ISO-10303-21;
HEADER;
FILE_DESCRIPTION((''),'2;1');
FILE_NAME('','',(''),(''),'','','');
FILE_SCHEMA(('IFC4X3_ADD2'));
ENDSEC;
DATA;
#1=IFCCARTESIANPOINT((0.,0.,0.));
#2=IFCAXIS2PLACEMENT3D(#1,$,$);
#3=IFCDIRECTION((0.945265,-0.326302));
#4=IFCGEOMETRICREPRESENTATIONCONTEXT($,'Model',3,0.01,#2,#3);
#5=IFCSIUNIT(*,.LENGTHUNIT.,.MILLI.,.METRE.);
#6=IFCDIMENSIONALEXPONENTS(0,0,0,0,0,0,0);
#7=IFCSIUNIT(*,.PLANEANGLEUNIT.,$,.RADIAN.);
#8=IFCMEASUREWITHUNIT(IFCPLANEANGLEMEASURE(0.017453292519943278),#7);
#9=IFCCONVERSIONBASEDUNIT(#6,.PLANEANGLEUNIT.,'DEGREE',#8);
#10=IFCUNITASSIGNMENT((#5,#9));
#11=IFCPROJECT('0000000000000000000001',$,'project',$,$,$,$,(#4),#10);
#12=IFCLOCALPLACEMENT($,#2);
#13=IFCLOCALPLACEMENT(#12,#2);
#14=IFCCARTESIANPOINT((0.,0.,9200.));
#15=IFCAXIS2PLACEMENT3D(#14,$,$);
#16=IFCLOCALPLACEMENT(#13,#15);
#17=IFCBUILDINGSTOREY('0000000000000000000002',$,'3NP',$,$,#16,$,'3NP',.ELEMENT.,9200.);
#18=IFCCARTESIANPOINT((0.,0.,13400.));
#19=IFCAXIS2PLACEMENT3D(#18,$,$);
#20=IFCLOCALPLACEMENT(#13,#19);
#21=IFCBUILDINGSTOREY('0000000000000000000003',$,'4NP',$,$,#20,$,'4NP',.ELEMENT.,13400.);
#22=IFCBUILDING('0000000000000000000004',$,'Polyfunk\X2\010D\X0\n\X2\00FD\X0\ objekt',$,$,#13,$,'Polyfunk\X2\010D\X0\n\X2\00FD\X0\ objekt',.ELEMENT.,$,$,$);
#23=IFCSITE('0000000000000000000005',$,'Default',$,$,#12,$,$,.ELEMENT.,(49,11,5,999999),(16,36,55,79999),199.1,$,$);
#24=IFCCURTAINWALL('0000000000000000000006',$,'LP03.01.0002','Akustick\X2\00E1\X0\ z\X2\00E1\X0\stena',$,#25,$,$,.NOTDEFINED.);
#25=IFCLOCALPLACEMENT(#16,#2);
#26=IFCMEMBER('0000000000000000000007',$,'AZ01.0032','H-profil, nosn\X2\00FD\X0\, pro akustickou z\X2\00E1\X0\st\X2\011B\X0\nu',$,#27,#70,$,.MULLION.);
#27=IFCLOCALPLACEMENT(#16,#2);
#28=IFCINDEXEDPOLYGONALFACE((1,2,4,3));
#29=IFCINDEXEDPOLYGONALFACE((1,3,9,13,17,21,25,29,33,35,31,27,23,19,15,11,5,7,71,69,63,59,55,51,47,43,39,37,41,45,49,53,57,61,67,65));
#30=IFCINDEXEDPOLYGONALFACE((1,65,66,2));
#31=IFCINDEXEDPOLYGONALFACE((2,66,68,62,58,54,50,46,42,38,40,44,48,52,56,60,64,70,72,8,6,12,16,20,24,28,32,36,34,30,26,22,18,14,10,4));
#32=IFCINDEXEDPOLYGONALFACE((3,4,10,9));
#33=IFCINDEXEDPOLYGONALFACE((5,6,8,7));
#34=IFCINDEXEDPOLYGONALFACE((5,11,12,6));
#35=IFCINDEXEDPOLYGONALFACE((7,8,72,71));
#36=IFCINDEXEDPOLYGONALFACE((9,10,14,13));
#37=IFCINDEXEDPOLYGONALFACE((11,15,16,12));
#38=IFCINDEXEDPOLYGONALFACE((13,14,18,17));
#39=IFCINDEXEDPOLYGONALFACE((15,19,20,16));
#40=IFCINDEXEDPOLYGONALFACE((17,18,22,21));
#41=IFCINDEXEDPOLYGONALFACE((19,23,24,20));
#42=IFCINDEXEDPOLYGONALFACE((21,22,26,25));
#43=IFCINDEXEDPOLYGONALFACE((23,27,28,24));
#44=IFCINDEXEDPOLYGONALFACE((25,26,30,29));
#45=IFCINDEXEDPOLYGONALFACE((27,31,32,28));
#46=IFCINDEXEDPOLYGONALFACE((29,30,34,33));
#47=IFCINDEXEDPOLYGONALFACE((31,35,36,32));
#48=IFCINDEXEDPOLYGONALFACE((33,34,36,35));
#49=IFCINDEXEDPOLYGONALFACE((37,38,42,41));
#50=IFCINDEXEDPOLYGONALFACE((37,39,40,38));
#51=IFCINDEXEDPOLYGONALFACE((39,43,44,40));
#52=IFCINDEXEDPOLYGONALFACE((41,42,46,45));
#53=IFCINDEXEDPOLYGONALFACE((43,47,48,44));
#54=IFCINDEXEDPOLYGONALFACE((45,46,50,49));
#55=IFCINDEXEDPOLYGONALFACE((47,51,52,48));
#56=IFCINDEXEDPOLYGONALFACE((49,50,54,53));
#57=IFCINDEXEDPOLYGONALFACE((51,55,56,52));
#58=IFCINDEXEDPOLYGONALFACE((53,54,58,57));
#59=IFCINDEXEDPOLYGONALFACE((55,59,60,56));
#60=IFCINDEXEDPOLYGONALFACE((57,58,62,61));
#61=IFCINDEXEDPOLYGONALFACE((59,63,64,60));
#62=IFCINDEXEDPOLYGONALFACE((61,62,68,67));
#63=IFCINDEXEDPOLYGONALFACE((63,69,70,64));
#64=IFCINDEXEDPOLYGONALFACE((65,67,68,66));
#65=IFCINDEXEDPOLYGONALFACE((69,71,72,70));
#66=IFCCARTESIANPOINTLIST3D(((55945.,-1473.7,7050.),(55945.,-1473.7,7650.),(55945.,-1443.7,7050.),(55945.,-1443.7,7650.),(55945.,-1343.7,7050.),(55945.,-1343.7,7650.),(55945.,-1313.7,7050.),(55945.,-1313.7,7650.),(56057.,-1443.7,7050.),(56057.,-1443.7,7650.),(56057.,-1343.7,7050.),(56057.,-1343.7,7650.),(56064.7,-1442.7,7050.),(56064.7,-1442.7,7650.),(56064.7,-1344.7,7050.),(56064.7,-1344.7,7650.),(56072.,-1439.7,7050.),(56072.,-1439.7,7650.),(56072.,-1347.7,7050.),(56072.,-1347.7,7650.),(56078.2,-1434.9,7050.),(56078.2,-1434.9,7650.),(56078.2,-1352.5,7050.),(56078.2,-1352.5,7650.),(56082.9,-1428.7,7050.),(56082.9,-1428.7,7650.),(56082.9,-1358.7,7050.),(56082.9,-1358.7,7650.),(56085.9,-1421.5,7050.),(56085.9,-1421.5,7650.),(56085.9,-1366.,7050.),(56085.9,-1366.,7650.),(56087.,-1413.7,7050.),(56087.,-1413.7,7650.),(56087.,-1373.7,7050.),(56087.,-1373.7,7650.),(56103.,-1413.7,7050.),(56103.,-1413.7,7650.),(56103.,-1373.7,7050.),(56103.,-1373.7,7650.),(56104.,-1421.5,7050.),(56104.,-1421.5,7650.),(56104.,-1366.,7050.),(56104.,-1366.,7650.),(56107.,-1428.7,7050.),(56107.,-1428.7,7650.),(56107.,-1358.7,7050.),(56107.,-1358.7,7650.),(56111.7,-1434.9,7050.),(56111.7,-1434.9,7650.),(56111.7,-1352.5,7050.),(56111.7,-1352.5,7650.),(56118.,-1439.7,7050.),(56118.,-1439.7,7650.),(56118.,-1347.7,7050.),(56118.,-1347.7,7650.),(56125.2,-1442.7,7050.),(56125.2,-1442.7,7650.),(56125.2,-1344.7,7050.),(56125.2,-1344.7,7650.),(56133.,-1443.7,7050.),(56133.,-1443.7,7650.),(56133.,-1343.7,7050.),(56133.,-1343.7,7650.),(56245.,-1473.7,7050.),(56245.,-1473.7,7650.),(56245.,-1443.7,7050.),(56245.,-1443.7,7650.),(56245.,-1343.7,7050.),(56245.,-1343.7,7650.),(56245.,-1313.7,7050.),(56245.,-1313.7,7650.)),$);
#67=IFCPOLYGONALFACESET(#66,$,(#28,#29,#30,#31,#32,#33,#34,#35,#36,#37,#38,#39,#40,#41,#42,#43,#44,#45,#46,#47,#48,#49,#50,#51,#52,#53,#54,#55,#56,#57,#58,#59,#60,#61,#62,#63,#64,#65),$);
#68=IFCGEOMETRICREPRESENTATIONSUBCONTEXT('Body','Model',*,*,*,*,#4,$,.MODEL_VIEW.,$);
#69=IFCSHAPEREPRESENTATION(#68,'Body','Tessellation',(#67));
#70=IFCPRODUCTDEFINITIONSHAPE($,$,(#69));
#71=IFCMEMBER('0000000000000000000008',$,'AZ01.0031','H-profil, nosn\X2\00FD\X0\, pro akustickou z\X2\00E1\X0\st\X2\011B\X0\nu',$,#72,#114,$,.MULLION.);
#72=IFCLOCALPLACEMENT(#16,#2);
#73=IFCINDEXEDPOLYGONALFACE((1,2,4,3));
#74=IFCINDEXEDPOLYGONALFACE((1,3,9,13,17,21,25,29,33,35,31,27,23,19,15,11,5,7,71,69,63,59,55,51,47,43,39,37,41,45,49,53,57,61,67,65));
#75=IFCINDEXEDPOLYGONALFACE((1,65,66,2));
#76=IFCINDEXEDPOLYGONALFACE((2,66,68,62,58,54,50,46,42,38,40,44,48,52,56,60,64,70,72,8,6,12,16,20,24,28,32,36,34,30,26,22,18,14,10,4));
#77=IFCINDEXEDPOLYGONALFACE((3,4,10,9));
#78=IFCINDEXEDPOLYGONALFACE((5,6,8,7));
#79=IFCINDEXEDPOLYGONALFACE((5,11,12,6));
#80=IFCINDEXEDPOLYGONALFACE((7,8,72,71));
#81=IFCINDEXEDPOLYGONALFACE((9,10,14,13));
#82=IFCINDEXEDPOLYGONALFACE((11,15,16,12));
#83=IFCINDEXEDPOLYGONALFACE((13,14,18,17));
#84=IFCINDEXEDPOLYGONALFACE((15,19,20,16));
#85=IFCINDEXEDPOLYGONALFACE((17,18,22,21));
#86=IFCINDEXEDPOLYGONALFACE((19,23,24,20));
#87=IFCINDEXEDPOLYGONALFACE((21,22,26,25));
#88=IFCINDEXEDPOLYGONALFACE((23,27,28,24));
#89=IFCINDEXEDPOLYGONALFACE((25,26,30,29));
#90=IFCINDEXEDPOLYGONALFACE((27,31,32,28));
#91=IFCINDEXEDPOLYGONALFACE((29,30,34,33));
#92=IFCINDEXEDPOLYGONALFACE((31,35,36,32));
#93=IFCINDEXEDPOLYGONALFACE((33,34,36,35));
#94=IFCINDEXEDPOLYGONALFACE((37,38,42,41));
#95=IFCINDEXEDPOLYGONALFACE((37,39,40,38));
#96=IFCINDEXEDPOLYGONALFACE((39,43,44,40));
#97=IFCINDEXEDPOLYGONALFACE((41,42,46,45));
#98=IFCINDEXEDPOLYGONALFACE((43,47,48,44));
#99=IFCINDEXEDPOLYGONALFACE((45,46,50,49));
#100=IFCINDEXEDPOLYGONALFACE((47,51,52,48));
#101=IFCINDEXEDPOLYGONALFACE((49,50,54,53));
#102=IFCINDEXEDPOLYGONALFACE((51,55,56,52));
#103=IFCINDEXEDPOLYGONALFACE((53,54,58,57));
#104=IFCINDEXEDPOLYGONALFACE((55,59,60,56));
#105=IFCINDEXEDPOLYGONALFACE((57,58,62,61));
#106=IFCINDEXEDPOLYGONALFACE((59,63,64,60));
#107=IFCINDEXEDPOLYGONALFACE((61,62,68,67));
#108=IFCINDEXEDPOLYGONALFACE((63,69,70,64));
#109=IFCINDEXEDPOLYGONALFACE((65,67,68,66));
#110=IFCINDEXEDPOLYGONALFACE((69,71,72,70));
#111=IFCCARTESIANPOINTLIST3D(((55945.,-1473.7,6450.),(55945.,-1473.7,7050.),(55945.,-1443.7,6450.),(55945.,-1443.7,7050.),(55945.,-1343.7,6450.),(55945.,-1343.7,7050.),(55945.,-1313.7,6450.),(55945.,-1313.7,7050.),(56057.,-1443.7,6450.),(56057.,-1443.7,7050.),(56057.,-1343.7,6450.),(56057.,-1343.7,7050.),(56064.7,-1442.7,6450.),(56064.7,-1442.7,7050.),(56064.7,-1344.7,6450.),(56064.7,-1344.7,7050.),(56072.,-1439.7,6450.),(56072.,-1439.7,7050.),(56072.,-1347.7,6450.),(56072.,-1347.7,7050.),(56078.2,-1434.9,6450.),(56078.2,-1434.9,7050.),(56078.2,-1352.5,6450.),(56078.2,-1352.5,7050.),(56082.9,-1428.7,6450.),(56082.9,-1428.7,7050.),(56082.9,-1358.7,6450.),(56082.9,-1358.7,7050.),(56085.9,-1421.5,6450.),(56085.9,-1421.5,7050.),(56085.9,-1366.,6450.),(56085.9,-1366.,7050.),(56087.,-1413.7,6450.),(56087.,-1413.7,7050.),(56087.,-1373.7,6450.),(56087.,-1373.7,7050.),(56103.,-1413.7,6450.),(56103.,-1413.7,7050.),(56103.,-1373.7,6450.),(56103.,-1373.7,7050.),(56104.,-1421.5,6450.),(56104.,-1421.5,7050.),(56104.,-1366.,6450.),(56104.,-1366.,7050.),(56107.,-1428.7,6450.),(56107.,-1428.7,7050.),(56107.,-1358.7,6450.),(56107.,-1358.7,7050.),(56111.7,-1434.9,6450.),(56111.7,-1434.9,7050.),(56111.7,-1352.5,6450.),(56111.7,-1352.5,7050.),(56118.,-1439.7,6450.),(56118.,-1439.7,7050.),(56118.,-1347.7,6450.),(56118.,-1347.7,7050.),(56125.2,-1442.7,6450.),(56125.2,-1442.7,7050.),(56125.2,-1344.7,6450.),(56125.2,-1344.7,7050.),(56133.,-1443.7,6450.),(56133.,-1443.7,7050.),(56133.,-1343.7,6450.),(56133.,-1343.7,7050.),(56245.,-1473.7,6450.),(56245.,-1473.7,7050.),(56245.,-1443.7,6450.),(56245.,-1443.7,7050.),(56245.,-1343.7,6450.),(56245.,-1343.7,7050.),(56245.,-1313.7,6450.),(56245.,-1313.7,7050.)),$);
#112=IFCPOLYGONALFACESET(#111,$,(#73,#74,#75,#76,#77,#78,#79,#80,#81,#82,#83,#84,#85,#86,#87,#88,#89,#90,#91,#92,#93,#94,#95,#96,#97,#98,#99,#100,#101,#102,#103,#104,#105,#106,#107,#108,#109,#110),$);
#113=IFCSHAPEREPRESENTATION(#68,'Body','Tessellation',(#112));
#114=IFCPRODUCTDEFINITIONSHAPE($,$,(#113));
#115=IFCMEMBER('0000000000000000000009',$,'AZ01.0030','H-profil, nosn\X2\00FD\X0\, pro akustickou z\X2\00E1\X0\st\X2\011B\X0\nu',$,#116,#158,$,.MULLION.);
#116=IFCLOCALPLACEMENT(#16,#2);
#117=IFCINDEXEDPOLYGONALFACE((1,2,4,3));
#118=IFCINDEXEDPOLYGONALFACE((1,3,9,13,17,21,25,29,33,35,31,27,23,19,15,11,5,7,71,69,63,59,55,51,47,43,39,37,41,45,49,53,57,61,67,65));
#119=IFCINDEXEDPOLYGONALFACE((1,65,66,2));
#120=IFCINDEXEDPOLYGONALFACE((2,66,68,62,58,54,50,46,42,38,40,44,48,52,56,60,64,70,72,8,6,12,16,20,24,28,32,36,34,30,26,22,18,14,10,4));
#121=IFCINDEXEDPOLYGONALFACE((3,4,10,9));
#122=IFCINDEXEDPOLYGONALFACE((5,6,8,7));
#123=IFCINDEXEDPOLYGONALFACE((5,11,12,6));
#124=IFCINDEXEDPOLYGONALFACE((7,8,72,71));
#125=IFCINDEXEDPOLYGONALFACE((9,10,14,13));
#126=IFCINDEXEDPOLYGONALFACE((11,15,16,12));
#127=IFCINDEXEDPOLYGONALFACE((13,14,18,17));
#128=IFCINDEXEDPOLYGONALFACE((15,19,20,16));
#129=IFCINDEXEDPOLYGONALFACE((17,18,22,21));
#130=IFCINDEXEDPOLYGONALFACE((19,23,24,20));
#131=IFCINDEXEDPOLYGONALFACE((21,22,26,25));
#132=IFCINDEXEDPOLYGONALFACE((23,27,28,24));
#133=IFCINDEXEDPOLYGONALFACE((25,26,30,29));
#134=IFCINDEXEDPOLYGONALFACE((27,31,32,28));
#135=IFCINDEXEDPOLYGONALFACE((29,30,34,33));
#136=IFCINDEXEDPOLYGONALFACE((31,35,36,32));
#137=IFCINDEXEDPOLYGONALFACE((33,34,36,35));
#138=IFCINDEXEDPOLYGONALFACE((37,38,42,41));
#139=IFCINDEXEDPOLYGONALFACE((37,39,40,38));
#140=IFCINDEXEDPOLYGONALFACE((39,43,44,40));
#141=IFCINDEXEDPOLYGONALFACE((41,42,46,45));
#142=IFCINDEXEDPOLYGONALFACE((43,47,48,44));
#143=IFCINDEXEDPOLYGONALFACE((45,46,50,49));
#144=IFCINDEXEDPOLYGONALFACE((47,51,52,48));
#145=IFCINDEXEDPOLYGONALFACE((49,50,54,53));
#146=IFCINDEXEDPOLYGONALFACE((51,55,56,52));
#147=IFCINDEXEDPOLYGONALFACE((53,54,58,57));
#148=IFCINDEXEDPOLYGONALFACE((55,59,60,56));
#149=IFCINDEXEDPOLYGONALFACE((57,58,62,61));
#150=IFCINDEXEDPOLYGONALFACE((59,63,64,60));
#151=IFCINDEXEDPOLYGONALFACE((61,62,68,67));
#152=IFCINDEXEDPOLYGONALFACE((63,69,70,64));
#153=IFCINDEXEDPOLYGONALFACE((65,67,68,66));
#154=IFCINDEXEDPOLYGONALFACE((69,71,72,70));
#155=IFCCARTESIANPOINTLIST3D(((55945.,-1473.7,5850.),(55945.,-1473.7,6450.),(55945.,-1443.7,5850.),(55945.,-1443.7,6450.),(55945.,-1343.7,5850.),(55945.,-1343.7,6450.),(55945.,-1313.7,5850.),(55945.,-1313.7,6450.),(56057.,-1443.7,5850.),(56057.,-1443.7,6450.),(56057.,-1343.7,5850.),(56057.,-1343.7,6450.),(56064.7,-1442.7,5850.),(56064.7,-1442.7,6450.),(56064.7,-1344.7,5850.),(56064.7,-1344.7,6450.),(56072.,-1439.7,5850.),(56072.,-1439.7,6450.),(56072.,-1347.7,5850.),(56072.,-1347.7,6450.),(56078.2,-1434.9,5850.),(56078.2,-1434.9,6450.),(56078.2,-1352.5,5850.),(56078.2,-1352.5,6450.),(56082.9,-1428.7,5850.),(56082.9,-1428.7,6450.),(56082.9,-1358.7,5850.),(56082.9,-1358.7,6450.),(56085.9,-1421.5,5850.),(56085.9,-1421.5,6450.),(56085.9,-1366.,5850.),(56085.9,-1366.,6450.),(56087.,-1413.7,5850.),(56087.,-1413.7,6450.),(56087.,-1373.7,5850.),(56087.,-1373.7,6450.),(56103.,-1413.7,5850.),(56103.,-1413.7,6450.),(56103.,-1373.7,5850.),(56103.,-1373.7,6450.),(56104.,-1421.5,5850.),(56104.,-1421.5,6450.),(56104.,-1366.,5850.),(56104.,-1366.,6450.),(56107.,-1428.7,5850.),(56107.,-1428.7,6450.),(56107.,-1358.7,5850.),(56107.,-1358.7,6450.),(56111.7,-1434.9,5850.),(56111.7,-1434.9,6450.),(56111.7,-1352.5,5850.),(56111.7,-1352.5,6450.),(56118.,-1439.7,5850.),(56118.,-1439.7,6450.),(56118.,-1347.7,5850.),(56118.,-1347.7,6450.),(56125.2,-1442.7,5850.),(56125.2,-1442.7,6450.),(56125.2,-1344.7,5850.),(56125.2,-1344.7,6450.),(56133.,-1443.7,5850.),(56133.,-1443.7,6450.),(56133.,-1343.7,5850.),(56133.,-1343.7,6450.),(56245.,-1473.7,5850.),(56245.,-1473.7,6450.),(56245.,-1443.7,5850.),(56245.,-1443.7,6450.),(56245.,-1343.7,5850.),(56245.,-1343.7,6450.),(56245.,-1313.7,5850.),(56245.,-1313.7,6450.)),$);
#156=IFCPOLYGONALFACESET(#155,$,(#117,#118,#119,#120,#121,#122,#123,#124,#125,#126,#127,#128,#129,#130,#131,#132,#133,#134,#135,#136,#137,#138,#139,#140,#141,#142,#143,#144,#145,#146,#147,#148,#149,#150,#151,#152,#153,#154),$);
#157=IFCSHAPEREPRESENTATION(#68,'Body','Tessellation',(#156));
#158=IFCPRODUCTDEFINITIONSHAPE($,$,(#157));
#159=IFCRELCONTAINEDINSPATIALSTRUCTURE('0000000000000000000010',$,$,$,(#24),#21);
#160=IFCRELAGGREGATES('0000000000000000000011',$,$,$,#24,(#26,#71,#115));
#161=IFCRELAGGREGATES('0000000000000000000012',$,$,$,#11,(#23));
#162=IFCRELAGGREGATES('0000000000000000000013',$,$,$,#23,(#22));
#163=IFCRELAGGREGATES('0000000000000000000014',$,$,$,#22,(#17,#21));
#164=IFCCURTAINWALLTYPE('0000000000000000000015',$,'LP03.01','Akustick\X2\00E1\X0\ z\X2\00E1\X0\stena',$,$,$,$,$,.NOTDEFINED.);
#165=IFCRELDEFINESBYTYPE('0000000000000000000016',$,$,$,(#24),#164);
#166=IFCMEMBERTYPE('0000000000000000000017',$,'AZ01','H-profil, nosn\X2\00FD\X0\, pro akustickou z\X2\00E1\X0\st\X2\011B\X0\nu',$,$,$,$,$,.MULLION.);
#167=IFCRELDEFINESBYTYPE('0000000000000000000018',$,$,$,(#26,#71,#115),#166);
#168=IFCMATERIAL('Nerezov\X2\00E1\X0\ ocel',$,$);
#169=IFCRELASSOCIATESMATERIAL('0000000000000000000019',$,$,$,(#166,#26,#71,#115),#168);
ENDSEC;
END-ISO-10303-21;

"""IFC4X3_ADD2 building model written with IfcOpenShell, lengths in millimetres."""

from ifc_helpers import new_model, entity, si_unit, converted_unit, direction, frame, frame_2d, origin, place, context, subcontext, project, spatial, polyline, circle_curve, parameter, trimmed, segment, composite_curve, outline, extrude, source, transform, mapped, material, material_profile, profile_set, profile_usage, type_object, element, aggregate, save


model = new_model("IFC4X3_ADD2")

# Units and contexts
model_context = context("Model", 3, precision=0.01, world=origin(), true_north=direction((0.945265, -0.326302)))
body_context = subcontext(model_context, "Body", "Model", "MODEL_VIEW")
ifc_project = project(units=[si_unit("LENGTHUNIT", "METRE", prefix="MILLI"), converted_unit("PLANEANGLEUNIT", "DEGREE", entity("IfcPlaneAngleMeasure", 0.017453292519943278), si_unit("PLANEANGLEUNIT", "RADIAN"), dimensions=[0, 0, 0, 0, 0, 0, 0])], contexts=[model_context])

# Site, building, storey
site_placement = place(None, origin())
site = spatial("IfcSite", under=ifc_project, at=site_placement, Name="Default", CompositionType="ELEMENT", RefLatitude=(49, 11, 5, 999999), RefLongitude=(16, 36, 55, 79999), RefElevation=199.1)
building_placement = place(site_placement, origin())
building = spatial("IfcBuilding", under=site, at=building_placement, Name="Polyfunkčný objekt", LongName="Polyfunkčný objekt", CompositionType="ELEMENT")
storey_1_placement = place(building_placement, frame((0.0, 0.0, 9200.0)))
storey_1 = spatial("IfcBuildingStorey", under=building, at=storey_1_placement, Name="3NP", LongName="3NP", CompositionType="ELEMENT", Elevation=9200.0)

# Shared definitions
storey_2_placement = place(building_placement, frame((0.0, 0.0, 13400.0)))
storey_2 = spatial("IfcBuildingStorey", under=building, at=storey_2_placement, Name="4NP", LongName="4NP", CompositionType="ELEMENT", Elevation=13400.0)

# Curtain wall, members
curtain_wall_type_1 = type_object("IfcCurtainWallType", Name="LP03.01", Description="Akustická zástena", PredefinedType="NOTDEFINED")
ifc_material_1 = material(Name="Nerezová ocel")
ifc_material_profile_1 = material_profile(ifc_material_1, outline(composite_curve([segment(polyline([(50.0, -150.0), (80.0, -150.0)]), True, "CONTINUOUS"), segment(polyline([(80.0, -150.0), (80.0, 150.0)]), True, "CONTINUOUS"), segment(polyline([(80.0, 150.0), (50.0, 150.0)]), True, "CONTINUOUS"), segment(polyline([(50.0, 150.0), (50.0, 38.0)]), True, "CONTINUOUS"), segment(trimmed(circle_curve(frame_2d((20.0, 38.0), x_axis=(0.0, 1.0)), 30.0), [parameter(180.0)], [parameter(270.0)], True, "PARAMETER"), False, "CONTINUOUS"), segment(polyline([(20.0, 8.0), (-20.0, 8.0)]), True, "CONTINUOUS"), segment(trimmed(circle_curve(frame_2d((-20.0, 38.0), x_axis=(0.0, 1.0)), 30.0), [parameter(90.0)], [parameter(180.0)], True, "PARAMETER"), False, "CONTINUOUS"), segment(polyline([(-50.0, 38.0), (-50.0, 150.0)]), True, "CONTINUOUS"), segment(polyline([(-50.0, 150.0), (-80.0, 150.0)]), True, "CONTINUOUS"), segment(polyline([(-80.0, 150.0), (-80.0, -150.0)]), True, "CONTINUOUS"), segment(polyline([(-80.0, -150.0), (-50.0, -150.0)]), True, "CONTINUOUS"), segment(polyline([(-50.0, -150.0), (-50.0, -38.0)]), True, "CONTINUOUS"), segment(trimmed(circle_curve(frame_2d((-20.0, -38.0), x_axis=(0.0, 1.0)), 30.0), [parameter(0.0)], [parameter(90.0)], True, "PARAMETER"), False, "CONTINUOUS"), segment(polyline([(-20.0, -8.0), (20.0, -8.0)]), True, "CONTINUOUS"), segment(trimmed(circle_curve(frame_2d((20.0, -38.0), x_axis=(0.0, 1.0)), 30.0), [parameter(270.0)], [parameter(0.0)], True, "PARAMETER"), False, "CONTINUOUS"), segment(polyline([(50.0, -38.0), (50.0, -150.0)]), True, "CONTINUOUS")], self_intersect=False)), Name="Profil zástena")
ifc_profile_set_1 = profile_set([ifc_material_profile_1], Name="Profil zástena")
ifc_profile_usage_1 = profile_usage(ifc_profile_set_1)
member_type_1 = type_object("IfcMemberType", Name="AZ01", Description="H-profil, nosný, pro akustickou zástěnu", PredefinedType="MULLION", material=ifc_profile_set_1)
curtain_wall_1_placement = place(storey_2_placement, frame((0.0, 0.0, -13400.0)))
curtain_wall_1 = element("IfcCurtainWall", 1, at=curtain_wall_1_placement, inside=storey_2, type_object=curtain_wall_type_1, Name="LP03.01.0002", Description="Akustická zástena", PredefinedType="NOTDEFINED")
shared_shape_1 = source(origin(), body_context, "Body", "SweptSolid", [
    extrude(outline(composite_curve([segment(polyline([(50.0, -150.0), (80.0, -150.0)]), True, "CONTINUOUS"), segment(polyline([(80.0, -150.0), (80.0, 150.0)]), True, "CONTINUOUS"), segment(polyline([(80.0, 150.0), (50.0, 150.0)]), True, "CONTINUOUS"), segment(polyline([(50.0, 150.0), (50.0, 38.0)]), True, "CONTINUOUS"), segment(trimmed(circle_curve(frame_2d((20.0, 38.0), x_axis=(0.0, 1.0)), 30.0), [parameter(180.0)], [parameter(270.0)], True, "PARAMETER"), False, "CONTINUOUS"), segment(polyline([(20.0, 8.0), (-20.0, 8.0)]), True, "CONTINUOUS"), segment(trimmed(circle_curve(frame_2d((-20.0, 38.0), x_axis=(0.0, 1.0)), 30.0), [parameter(90.0)], [parameter(180.0)], True, "PARAMETER"), False, "CONTINUOUS"), segment(polyline([(-50.0, 38.0), (-50.0, 150.0)]), True, "CONTINUOUS"), segment(polyline([(-50.0, 150.0), (-80.0, 150.0)]), True, "CONTINUOUS"), segment(polyline([(-80.0, 150.0), (-80.0, -150.0)]), True, "CONTINUOUS"), segment(polyline([(-80.0, -150.0), (-50.0, -150.0)]), True, "CONTINUOUS"), segment(polyline([(-50.0, -150.0), (-50.0, -38.0)]), True, "CONTINUOUS"), segment(trimmed(circle_curve(frame_2d((-20.0, -38.0), x_axis=(0.0, 1.0)), 30.0), [parameter(0.0)], [parameter(90.0)], True, "PARAMETER"), False, "CONTINUOUS"), segment(polyline([(-20.0, -8.0), (20.0, -8.0)]), True, "CONTINUOUS"), segment(trimmed(circle_curve(frame_2d((20.0, -38.0), x_axis=(0.0, 1.0)), 30.0), [parameter(270.0)], [parameter(0.0)], True, "PARAMETER"), False, "CONTINUOUS"), segment(polyline([(50.0, -38.0), (50.0, -150.0)]), True, "CONTINUOUS")], self_intersect=False)), frame((-150.0, 0.0, -600.0), z_axis=(0.0, 0.0, 1.0), x_axis=(0.0, -1.0, 0.0)), (0.0, 0.0, 1.0), 600.0),
])
member_1_placement = place(curtain_wall_1_placement, frame((56245.0, -1393.7, 16250.0), z_axis=(0.0, 0.0, -1.0), x_axis=(1.0, 0.0, 0.0)))
member_1 = element("IfcMember", 2, at=member_1_placement, type_object=member_type_1, material=ifc_profile_usage_1, Name="AZ01.0032", Description="H-profil, nosný, pro akustickou zástěnu", PredefinedType="MULLION", context=body_context, shape_type="MappedRepresentation", body=[
    mapped(shared_shape_1, transform((0.0, 0.0, 0.0), scale=1.0)),
])
member_2_placement = place(curtain_wall_1_placement, frame((56245.0, -1393.7, 15650.0), z_axis=(0.0, 0.0, -1.0), x_axis=(1.0, 0.0, 0.0)))
member_2 = element("IfcMember", 3, at=member_2_placement, type_object=member_type_1, material=ifc_profile_usage_1, Name="AZ01.0031", Description="H-profil, nosný, pro akustickou zástěnu", PredefinedType="MULLION", context=body_context, shape_type="MappedRepresentation", body=[
    mapped(shared_shape_1, transform((0.0, 0.0, 0.0), scale=1.0)),
])
member_3_placement = place(curtain_wall_1_placement, frame((56245.0, -1393.7, 15050.0), z_axis=(0.0, 0.0, -1.0), x_axis=(1.0, 0.0, 0.0)))
member_3 = element("IfcMember", 4, at=member_3_placement, type_object=member_type_1, material=ifc_profile_usage_1, Name="AZ01.0030", Description="H-profil, nosný, pro akustickou zástěnu", PredefinedType="MULLION", context=body_context, shape_type="MappedRepresentation", body=[
    mapped(shared_shape_1, transform((0.0, 0.0, 0.0), scale=1.0)),
])
aggregate(curtain_wall_1, [member_1, member_2, member_3])

save(model, "model.ifc")
